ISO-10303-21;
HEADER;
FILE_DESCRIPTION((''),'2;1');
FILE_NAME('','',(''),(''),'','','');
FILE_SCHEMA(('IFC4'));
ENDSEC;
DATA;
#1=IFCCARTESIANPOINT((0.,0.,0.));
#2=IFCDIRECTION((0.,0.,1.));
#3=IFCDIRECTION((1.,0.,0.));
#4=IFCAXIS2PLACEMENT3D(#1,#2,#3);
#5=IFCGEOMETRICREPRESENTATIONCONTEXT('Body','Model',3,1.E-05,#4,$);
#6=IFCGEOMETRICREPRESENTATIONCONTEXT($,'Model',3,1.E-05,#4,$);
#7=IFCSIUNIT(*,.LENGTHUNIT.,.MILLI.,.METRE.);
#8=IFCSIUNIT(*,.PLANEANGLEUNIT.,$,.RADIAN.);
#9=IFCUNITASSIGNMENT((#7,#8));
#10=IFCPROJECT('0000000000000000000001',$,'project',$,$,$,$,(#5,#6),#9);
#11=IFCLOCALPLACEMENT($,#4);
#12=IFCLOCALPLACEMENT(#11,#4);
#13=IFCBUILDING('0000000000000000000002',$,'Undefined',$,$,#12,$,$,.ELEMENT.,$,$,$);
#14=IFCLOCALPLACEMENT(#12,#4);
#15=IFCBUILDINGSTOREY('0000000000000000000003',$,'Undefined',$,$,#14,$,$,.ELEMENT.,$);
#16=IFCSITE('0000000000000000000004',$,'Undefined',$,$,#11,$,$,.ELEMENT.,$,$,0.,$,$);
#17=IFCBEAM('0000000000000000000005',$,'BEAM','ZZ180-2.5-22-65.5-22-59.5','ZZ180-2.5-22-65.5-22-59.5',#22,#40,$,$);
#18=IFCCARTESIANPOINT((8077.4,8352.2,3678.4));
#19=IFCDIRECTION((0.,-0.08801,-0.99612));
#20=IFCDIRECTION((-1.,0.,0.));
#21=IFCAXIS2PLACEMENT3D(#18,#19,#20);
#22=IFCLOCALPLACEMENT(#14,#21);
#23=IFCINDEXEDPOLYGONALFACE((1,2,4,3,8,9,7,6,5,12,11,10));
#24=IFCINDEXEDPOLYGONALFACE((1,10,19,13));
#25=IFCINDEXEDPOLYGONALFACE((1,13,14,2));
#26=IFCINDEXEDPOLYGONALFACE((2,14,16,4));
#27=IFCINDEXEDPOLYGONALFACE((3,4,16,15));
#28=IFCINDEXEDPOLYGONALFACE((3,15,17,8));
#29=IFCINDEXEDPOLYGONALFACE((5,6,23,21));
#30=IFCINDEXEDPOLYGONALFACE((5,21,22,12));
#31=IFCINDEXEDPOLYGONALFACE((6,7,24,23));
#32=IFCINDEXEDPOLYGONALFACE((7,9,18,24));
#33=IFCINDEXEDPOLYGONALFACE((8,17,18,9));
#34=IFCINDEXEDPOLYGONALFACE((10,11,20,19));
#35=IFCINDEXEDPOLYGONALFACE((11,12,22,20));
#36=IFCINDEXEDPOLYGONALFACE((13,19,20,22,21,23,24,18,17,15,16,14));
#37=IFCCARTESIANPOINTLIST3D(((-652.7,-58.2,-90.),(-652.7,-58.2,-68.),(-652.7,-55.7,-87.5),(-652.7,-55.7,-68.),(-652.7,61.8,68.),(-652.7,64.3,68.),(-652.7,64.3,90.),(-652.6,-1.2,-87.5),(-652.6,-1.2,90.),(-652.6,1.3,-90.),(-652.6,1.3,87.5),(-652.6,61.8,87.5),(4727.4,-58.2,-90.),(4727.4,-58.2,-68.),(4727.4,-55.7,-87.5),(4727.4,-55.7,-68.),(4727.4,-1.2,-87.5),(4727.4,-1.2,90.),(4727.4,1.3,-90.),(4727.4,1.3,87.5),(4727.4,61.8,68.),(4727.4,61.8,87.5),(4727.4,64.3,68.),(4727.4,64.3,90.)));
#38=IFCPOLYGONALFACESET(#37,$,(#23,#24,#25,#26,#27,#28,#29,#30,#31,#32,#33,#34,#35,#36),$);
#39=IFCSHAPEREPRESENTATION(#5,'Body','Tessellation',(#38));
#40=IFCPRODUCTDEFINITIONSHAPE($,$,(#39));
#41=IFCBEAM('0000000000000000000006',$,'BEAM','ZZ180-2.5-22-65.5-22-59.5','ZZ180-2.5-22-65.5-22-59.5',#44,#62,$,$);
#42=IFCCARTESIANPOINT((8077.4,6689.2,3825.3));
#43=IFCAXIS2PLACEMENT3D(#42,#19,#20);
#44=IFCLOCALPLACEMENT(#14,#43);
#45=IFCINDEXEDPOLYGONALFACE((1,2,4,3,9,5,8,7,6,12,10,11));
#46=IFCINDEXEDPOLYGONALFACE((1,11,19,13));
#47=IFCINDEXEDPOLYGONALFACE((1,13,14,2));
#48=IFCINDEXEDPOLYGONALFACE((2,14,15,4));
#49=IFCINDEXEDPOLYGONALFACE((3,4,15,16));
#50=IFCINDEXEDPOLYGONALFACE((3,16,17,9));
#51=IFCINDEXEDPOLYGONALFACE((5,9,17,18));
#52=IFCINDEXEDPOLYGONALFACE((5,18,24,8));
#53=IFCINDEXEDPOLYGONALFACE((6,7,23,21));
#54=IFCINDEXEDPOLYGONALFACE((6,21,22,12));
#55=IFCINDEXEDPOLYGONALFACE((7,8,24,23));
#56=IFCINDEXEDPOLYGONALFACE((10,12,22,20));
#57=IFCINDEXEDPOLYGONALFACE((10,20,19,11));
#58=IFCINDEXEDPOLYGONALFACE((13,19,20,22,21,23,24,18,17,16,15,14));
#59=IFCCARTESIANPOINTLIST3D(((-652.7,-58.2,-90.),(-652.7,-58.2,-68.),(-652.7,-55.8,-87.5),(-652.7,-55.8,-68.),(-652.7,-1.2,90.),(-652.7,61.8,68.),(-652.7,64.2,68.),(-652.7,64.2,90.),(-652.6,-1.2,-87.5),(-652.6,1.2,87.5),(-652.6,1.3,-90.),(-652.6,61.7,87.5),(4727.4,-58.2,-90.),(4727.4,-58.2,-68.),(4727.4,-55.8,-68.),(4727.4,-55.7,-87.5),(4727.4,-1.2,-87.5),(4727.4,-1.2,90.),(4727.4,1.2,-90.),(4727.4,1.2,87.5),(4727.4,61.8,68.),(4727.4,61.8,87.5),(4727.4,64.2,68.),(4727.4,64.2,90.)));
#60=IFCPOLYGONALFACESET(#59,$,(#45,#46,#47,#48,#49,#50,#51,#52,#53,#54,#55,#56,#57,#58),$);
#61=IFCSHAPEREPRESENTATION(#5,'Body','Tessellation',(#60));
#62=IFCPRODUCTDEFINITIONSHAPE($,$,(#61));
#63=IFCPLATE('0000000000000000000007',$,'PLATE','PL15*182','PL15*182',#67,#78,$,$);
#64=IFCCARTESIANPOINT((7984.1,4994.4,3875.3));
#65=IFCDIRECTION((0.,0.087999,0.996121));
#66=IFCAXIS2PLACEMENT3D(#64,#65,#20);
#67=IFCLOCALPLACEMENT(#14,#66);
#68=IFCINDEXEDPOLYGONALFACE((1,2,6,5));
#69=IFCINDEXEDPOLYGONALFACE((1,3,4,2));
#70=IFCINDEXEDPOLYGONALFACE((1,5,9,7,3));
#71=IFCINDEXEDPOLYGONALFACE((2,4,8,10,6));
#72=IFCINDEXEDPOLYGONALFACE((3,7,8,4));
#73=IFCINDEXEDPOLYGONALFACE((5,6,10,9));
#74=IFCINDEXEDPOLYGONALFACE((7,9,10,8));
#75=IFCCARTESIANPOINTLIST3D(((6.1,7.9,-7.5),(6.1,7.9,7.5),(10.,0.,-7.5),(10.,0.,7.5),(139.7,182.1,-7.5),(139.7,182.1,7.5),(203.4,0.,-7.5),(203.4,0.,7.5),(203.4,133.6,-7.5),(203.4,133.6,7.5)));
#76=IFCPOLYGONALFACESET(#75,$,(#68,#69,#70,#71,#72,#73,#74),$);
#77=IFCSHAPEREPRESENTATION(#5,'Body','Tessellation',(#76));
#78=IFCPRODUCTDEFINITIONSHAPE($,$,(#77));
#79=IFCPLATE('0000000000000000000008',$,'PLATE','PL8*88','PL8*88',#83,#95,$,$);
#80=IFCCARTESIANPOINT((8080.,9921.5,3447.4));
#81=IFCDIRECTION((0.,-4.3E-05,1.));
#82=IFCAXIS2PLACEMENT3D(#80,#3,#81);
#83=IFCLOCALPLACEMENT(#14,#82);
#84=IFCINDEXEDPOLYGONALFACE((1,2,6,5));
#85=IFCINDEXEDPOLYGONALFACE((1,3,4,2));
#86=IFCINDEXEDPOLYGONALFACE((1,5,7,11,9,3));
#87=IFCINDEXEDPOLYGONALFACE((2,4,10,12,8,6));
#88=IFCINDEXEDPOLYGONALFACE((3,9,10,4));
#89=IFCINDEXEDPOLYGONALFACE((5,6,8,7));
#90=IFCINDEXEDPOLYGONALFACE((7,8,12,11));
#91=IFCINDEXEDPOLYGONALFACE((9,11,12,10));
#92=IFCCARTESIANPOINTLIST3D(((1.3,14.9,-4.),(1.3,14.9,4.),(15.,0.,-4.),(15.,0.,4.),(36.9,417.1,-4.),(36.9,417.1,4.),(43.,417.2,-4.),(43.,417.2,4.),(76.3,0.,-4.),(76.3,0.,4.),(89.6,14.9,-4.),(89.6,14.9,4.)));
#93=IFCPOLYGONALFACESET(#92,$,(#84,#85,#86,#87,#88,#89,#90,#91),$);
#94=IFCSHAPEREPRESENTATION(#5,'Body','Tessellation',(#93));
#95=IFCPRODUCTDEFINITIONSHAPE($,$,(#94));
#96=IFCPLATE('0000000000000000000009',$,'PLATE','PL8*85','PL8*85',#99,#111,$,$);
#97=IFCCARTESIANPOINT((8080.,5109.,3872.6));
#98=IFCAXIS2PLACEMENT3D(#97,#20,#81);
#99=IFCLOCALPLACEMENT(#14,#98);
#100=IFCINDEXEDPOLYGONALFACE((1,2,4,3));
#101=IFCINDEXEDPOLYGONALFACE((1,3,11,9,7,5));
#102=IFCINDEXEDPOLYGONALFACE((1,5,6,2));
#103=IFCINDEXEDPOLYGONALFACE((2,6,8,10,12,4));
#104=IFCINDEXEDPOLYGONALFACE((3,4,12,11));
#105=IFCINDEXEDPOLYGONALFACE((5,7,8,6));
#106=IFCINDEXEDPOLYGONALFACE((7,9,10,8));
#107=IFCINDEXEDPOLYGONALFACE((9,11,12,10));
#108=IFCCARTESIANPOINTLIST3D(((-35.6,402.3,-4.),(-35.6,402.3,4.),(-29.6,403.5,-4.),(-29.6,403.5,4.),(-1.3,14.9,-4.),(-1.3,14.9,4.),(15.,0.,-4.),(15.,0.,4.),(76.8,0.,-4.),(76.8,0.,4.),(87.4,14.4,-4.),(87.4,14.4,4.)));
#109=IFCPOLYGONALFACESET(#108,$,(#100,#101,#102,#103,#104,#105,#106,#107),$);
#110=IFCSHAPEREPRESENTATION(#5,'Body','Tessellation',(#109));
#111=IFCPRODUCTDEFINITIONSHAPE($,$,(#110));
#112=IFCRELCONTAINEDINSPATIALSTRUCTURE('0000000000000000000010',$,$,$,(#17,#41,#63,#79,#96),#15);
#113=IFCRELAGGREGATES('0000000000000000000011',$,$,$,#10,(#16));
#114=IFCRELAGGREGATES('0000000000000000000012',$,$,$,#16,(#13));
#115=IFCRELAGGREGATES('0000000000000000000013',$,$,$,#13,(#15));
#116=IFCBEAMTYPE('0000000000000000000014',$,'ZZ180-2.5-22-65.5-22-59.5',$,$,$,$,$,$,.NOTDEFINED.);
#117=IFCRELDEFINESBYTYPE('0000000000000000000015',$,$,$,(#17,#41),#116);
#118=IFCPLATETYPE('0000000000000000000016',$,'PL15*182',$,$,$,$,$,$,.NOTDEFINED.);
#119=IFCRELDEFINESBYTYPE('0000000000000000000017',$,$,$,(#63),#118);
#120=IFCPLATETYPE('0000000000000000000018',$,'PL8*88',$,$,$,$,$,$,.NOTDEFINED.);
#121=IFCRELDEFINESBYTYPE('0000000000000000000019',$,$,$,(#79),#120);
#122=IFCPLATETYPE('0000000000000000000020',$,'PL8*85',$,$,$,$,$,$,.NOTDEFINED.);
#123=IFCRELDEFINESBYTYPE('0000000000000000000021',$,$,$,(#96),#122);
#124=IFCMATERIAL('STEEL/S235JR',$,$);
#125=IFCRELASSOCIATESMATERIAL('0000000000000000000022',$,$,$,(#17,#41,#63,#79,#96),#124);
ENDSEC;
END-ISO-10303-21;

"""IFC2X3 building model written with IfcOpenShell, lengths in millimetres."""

from ifc_helpers import new_model, si_unit, frame, origin_with_axes, place, context, project, spatial, polyline, outline, extrude, material, type_object, element, save


model = new_model("IFC2X3")

# Units and contexts
model_context_1 = context("Model", 3, precision=1e-05, world=origin_with_axes(), identifier="Body")
model_context_2 = context("Model", 3, precision=1e-05, world=origin_with_axes())
ifc_project = project(units=[si_unit("LENGTHUNIT", "METRE", prefix="MILLI"), si_unit("PLANEANGLEUNIT", "RADIAN")], contexts=[model_context_1, model_context_2])

# Site, building, storey
site_placement = place(None, origin_with_axes())
site = spatial("IfcSite", under=ifc_project, at=site_placement, Name="Undefined", CompositionType="ELEMENT", RefElevation=0.0)
building_placement = place(site_placement, origin_with_axes())
building = spatial("IfcBuilding", under=site, at=building_placement, Name="Undefined", CompositionType="ELEMENT")
storey_placement = place(building_placement, origin_with_axes())
storey = spatial("IfcBuildingStorey", under=building, at=storey_placement, Name="Undefined", CompositionType="ELEMENT")

# Shared definitions
ifc_material = material(Name="STEEL/S235JR")

# Beams
beam_type_1 = type_object("IfcBeamType", Name="ZZ180-2.5-22-65.5-22-59.5", PredefinedType="NOTDEFINED")
for number, where, z_axis, x_axis, name in (
    (1, (8077.4, 8352.2, 3678.4), (0.0, -0.08801, -0.99612), (-1.0, 0.0, 0.0), "BEAM"),
    (2, (8077.4, 6689.2, 3825.3), (0.0, -0.08801, -0.99612), (-1.0, 0.0, 0.0), "BEAM"),
):
    element("IfcBeam", number, at=place(storey_placement, frame(where, z_axis=z_axis, x_axis=x_axis)), inside=storey, type_object=beam_type_1, material=ifc_material, Name=name, Description="ZZ180-2.5-22-65.5-22-59.5", ObjectType="ZZ180-2.5-22-65.5-22-59.5", context=model_context_1, shape_type="SweptSolid", body=[
        extrude(outline(polyline([(58.2, -90.0), (58.2, -68.0), (55.8, -68.0), (55.8, -87.5), (1.2, -87.5), (1.2, 90.0), (-64.2, 90.0), (-64.2, 68.0), (-61.8, 68.0), (-61.8, 87.5), (-1.2, 87.5), (-1.2, -90.0), (58.2, -90.0)])), frame((4727.4, 0.0, 0.0), z_axis=(-1.0, 0.0, 0.0), x_axis=(0.0, -1.0, 0.0)), (0.0, 0.0, 1.0), 5380.0),
    ])

# Plates
plate_type_1 = type_object("IfcPlateType", Name="PL15*182", PredefinedType="NOTDEFINED")
plate_1_placement = place(storey_placement, frame((7984.1, 4994.4, 3875.3), z_axis=(0.0, 0.087999, 0.996121), x_axis=(-1.0, 0.0, 0.0)))
element("IfcPlate", 3, at=plate_1_placement, inside=storey, type_object=plate_type_1, material=ifc_material, Name="PLATE", Description="PL15*182", ObjectType="PL15*182", context=model_context_1, shape_type="SweptSolid", body=[
    extrude(outline(polyline([(6.1, 7.9), (10.0, 0.0), (203.4, 0.0), (203.4, 133.6), (139.7, 182.1), (6.1, 7.9)])), frame((0.0, 0.0, -7.5), z_axis=(0.0, 0.0, 1.0), x_axis=(1.0, 0.0, 0.0)), (0.0, 0.0, 1.0), 15.0),
])
plate_type_2 = type_object("IfcPlateType", Name="PL8*88", PredefinedType="NOTDEFINED")
plate_2_placement = place(storey_placement, frame((8080.0, 9921.5, 3447.4), z_axis=(1.0, 0.0, 0.0), x_axis=(0.0, -0.000043, 1.0)))
element("IfcPlate", 4, at=plate_2_placement, inside=storey, type_object=plate_type_2, material=ifc_material, Name="PLATE", Description="PL8*88", ObjectType="PL8*88", context=model_context_1, shape_type="SweptSolid", body=[
    extrude(outline(polyline([(1.3, 14.9), (15.0, 0.0), (76.3, 0.0), (89.6, 14.9), (43.0, 417.2), (36.9, 417.1), (1.3, 14.9)])), frame((0.0, 0.0, -4.0), z_axis=(0.0, 0.0, 1.0), x_axis=(1.0, 0.0, 0.0)), (0.0, 0.0, 1.0), 8.0),
])
plate_type_3 = type_object("IfcPlateType", Name="PL8*85", PredefinedType="NOTDEFINED")
plate_3_placement = place(storey_placement, frame((8080.0, 5109.0, 3872.6), z_axis=(-1.0, 0.0, 0.0), x_axis=(0.0, -0.000043, 1.0)))
element("IfcPlate", 5, at=plate_3_placement, inside=storey, type_object=plate_type_3, material=ifc_material, Name="PLATE", Description="PL8*85", ObjectType="PL8*85", context=model_context_1, shape_type="SweptSolid", body=[
    extrude(outline(polyline([(-1.3, 14.9), (15.0, 0.0), (76.8, 0.0), (87.4, 14.4), (-29.6, 403.5), (-35.6, 402.3), (-1.3, 14.9)])), frame((0.0, 0.0, -4.0), z_axis=(0.0, 0.0, 1.0), x_axis=(1.0, 0.0, 0.0)), (0.0, 0.0, 1.0), 8.0),
])

save(model, "model.ifc")
